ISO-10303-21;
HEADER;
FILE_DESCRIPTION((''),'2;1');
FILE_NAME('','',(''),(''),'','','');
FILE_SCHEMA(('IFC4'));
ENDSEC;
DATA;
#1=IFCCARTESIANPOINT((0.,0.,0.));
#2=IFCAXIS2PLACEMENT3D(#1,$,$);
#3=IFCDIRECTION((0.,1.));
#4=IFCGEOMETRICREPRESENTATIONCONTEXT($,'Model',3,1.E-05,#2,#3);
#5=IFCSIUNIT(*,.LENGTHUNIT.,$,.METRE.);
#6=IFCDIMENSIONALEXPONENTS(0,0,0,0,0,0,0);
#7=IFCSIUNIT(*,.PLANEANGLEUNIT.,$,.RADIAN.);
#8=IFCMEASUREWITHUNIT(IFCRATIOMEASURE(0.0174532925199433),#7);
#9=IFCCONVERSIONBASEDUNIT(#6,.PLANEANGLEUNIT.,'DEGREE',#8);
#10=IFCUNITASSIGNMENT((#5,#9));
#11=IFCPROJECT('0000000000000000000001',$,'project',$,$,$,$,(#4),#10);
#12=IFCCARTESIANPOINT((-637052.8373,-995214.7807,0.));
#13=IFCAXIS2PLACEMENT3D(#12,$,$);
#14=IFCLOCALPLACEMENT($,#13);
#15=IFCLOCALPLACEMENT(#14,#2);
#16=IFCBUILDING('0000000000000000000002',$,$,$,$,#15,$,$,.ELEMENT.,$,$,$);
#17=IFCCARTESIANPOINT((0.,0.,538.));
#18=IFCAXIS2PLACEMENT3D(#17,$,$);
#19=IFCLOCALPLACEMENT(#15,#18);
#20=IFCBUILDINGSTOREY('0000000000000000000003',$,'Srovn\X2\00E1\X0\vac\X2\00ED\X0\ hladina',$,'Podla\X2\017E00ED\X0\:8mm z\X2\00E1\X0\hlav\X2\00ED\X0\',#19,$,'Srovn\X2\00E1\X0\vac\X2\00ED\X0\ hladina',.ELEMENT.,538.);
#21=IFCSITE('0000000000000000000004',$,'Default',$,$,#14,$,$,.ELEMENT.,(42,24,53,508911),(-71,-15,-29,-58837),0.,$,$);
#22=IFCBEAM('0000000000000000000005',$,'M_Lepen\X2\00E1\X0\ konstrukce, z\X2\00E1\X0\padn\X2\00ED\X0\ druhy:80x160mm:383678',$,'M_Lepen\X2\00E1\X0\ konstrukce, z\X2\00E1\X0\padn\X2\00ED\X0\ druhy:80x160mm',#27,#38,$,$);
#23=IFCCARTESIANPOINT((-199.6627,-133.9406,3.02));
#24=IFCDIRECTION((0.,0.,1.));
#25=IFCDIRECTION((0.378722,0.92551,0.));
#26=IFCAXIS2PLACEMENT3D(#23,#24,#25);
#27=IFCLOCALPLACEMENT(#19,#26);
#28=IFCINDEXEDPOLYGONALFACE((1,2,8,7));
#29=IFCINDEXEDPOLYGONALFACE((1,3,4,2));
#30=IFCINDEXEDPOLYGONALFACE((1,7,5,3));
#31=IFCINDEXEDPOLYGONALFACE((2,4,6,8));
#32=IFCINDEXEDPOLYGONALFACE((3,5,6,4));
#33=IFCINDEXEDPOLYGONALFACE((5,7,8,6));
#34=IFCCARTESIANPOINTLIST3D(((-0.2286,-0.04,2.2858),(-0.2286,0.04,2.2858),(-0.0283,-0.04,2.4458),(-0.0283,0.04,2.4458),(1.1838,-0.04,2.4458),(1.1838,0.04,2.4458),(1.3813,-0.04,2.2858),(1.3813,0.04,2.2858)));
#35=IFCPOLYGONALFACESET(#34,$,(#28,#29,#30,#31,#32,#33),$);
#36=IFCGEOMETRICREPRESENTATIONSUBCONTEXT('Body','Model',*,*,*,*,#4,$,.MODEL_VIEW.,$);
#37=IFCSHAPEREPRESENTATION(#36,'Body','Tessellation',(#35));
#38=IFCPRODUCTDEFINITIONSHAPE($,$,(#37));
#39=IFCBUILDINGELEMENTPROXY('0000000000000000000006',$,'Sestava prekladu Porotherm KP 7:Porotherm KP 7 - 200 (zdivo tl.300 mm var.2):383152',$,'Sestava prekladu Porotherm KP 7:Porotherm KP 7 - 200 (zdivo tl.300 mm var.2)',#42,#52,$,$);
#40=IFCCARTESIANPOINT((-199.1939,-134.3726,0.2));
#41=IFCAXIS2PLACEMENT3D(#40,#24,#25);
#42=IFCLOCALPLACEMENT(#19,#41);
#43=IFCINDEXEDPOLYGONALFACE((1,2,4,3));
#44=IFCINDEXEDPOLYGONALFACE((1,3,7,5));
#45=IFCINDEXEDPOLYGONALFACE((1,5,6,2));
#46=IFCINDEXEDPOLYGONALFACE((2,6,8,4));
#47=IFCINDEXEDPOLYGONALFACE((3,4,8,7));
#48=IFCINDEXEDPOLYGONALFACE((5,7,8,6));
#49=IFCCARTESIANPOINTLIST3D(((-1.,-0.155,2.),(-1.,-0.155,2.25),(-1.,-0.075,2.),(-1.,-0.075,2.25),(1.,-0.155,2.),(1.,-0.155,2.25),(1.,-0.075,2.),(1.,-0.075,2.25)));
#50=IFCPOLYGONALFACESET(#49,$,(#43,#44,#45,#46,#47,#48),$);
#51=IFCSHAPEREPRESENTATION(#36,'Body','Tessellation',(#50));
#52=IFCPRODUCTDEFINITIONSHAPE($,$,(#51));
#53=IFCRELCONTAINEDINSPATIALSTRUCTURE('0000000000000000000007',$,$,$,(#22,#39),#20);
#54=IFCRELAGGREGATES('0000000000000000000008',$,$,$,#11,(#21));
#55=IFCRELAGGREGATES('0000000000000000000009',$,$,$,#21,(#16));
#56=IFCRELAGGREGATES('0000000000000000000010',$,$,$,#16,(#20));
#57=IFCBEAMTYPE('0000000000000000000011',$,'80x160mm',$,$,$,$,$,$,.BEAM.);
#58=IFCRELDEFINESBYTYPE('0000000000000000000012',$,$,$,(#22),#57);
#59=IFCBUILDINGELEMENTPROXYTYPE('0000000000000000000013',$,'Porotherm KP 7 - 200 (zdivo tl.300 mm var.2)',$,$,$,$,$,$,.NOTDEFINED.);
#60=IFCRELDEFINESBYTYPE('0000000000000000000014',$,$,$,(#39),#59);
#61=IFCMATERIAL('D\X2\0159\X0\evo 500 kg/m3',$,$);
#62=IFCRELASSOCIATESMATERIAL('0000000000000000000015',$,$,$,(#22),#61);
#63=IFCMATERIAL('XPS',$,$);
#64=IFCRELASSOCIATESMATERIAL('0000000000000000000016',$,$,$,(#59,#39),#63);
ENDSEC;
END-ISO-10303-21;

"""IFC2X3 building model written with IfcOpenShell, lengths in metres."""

from ifc_helpers import new_model, entity, si_unit, converted_unit, direction, frame, frame_2d, origin, origin_2d_with_axis, place, context, subcontext, project, spatial, rectangle, extrude, clip, halfspace, source, transform, mapped, material, type_object, type_shapes, element, save


model = new_model("IFC2X3")

# Units and contexts
model_context = context("Model", 3, precision=1e-05, world=origin(), true_north=direction((0.0, 1.0)))
body_context = subcontext(model_context, "Body", "Model", "MODEL_VIEW")
ifc_project = project(units=[si_unit("LENGTHUNIT", "METRE"), converted_unit("PLANEANGLEUNIT", "DEGREE", entity("IfcRatioMeasure", 0.0174532925199433), si_unit("PLANEANGLEUNIT", "RADIAN"), dimensions=[0, 0, 0, 0, 0, 0, 0])], contexts=[model_context])

# Site, building, storey
site_placement = place(None, frame((-637052.8373, -995214.7807, 0.0)))
site = spatial("IfcSite", under=ifc_project, at=site_placement, Name="Default", CompositionType="ELEMENT", RefLatitude=(42, 24, 53, 508911), RefLongitude=(-71, -15, -29, -58837), RefElevation=0.0)
building_placement = place(site_placement, origin())
building = spatial("IfcBuilding", under=site, at=building_placement, CompositionType="ELEMENT")
storey_placement = place(building_placement, frame((0.0, 0.0, 538.0)))
storey = spatial("IfcBuildingStorey", under=building, at=storey_placement, Name="Srovnávací hladina", ObjectType="Podlaží:8mm záhlaví", LongName="Srovnávací hladina", CompositionType="ELEMENT", Elevation=538.0)

# Beam
ifc_material_1 = material(Name="Dřevo 500 kg/m3")
beam_type_1 = type_object("IfcBeamType", Name="80x160mm", PredefinedType="BEAM")
beam_1_placement = place(storey_placement, frame((-199.6627, -133.9406, 3.02), z_axis=(0.0, 0.0, 1.0), x_axis=(0.378722, 0.92551, 0.0)))
element("IfcBeam", 1, at=beam_1_placement, inside=storey, type_object=beam_type_1, material=ifc_material_1, Name="M_Lepená konstrukce, západní druhy:80x160mm:383678", ObjectType="M_Lepená konstrukce, západní druhy:80x160mm", context=body_context, shape_type="Clipping", body=[
    clip(clip(extrude(rectangle(XDim=0.16, YDim=0.08, at=origin_2d_with_axis()), frame((-0.2286, 0.0, 2.3658), z_axis=(1.0, 0.0, 0.0), x_axis=(0.0, 0.0, -1.0)), (0.0, 0.0, 1.0), 1.6099), halfspace(frame((1.1838, -0.0475, 2.4458), z_axis=(0.629499, 0.0, 0.777001), x_axis=(-0.777001, 0.0, 0.629499)), False)), halfspace(frame((-0.0283, -0.0475, 2.4458), z_axis=(-0.624034, 0.0, 0.781397), x_axis=(0.781397, 0.0, 0.624034)), False)),
])

# Building element proxy
ifc_material_2 = material(Name="XPS")
building_element_proxy_type = type_object("IfcBuildingElementProxyType", Name="Porotherm KP 7 - 200 (zdivo tl.300 mm var.2)", PredefinedType="NOTDEFINED", material=ifc_material_2)
shared_shape = source(origin(), body_context, "Body", "SweptSolid", [
    extrude(rectangle(XDim=0.08, YDim=2.0, at=frame_2d((0.0, 0.0), x_axis=(1.0, 0.0))), frame((0.0, -0.115, 2.0), z_axis=(0.0, 0.0, 1.0), x_axis=(0.0, 1.0, 0.0)), (0.0, 0.0, 1.0), 0.25),
])
type_shapes(building_element_proxy_type, [shared_shape])
proxy_placement = place(storey_placement, frame((-199.1939, -134.3726, 0.2), z_axis=(0.0, 0.0, 1.0), x_axis=(0.378722, 0.92551, 0.0)))
element("IfcBuildingElementProxy", 2, at=proxy_placement, inside=storey, type_object=building_element_proxy_type, material=ifc_material_2, Name="Sestava prekladu Porotherm KP 7:Porotherm KP 7 - 200 (zdivo tl.300 mm var.2):383152", ObjectType="Sestava prekladu Porotherm KP 7:Porotherm KP 7 - 200 (zdivo tl.300 mm var.2)", context=body_context, shape_type="MappedRepresentation", body=[
    mapped(shared_shape, transform((0.0, 0.0, 0.0), scale=1.0)),
])

save(model, "model.ifc")
